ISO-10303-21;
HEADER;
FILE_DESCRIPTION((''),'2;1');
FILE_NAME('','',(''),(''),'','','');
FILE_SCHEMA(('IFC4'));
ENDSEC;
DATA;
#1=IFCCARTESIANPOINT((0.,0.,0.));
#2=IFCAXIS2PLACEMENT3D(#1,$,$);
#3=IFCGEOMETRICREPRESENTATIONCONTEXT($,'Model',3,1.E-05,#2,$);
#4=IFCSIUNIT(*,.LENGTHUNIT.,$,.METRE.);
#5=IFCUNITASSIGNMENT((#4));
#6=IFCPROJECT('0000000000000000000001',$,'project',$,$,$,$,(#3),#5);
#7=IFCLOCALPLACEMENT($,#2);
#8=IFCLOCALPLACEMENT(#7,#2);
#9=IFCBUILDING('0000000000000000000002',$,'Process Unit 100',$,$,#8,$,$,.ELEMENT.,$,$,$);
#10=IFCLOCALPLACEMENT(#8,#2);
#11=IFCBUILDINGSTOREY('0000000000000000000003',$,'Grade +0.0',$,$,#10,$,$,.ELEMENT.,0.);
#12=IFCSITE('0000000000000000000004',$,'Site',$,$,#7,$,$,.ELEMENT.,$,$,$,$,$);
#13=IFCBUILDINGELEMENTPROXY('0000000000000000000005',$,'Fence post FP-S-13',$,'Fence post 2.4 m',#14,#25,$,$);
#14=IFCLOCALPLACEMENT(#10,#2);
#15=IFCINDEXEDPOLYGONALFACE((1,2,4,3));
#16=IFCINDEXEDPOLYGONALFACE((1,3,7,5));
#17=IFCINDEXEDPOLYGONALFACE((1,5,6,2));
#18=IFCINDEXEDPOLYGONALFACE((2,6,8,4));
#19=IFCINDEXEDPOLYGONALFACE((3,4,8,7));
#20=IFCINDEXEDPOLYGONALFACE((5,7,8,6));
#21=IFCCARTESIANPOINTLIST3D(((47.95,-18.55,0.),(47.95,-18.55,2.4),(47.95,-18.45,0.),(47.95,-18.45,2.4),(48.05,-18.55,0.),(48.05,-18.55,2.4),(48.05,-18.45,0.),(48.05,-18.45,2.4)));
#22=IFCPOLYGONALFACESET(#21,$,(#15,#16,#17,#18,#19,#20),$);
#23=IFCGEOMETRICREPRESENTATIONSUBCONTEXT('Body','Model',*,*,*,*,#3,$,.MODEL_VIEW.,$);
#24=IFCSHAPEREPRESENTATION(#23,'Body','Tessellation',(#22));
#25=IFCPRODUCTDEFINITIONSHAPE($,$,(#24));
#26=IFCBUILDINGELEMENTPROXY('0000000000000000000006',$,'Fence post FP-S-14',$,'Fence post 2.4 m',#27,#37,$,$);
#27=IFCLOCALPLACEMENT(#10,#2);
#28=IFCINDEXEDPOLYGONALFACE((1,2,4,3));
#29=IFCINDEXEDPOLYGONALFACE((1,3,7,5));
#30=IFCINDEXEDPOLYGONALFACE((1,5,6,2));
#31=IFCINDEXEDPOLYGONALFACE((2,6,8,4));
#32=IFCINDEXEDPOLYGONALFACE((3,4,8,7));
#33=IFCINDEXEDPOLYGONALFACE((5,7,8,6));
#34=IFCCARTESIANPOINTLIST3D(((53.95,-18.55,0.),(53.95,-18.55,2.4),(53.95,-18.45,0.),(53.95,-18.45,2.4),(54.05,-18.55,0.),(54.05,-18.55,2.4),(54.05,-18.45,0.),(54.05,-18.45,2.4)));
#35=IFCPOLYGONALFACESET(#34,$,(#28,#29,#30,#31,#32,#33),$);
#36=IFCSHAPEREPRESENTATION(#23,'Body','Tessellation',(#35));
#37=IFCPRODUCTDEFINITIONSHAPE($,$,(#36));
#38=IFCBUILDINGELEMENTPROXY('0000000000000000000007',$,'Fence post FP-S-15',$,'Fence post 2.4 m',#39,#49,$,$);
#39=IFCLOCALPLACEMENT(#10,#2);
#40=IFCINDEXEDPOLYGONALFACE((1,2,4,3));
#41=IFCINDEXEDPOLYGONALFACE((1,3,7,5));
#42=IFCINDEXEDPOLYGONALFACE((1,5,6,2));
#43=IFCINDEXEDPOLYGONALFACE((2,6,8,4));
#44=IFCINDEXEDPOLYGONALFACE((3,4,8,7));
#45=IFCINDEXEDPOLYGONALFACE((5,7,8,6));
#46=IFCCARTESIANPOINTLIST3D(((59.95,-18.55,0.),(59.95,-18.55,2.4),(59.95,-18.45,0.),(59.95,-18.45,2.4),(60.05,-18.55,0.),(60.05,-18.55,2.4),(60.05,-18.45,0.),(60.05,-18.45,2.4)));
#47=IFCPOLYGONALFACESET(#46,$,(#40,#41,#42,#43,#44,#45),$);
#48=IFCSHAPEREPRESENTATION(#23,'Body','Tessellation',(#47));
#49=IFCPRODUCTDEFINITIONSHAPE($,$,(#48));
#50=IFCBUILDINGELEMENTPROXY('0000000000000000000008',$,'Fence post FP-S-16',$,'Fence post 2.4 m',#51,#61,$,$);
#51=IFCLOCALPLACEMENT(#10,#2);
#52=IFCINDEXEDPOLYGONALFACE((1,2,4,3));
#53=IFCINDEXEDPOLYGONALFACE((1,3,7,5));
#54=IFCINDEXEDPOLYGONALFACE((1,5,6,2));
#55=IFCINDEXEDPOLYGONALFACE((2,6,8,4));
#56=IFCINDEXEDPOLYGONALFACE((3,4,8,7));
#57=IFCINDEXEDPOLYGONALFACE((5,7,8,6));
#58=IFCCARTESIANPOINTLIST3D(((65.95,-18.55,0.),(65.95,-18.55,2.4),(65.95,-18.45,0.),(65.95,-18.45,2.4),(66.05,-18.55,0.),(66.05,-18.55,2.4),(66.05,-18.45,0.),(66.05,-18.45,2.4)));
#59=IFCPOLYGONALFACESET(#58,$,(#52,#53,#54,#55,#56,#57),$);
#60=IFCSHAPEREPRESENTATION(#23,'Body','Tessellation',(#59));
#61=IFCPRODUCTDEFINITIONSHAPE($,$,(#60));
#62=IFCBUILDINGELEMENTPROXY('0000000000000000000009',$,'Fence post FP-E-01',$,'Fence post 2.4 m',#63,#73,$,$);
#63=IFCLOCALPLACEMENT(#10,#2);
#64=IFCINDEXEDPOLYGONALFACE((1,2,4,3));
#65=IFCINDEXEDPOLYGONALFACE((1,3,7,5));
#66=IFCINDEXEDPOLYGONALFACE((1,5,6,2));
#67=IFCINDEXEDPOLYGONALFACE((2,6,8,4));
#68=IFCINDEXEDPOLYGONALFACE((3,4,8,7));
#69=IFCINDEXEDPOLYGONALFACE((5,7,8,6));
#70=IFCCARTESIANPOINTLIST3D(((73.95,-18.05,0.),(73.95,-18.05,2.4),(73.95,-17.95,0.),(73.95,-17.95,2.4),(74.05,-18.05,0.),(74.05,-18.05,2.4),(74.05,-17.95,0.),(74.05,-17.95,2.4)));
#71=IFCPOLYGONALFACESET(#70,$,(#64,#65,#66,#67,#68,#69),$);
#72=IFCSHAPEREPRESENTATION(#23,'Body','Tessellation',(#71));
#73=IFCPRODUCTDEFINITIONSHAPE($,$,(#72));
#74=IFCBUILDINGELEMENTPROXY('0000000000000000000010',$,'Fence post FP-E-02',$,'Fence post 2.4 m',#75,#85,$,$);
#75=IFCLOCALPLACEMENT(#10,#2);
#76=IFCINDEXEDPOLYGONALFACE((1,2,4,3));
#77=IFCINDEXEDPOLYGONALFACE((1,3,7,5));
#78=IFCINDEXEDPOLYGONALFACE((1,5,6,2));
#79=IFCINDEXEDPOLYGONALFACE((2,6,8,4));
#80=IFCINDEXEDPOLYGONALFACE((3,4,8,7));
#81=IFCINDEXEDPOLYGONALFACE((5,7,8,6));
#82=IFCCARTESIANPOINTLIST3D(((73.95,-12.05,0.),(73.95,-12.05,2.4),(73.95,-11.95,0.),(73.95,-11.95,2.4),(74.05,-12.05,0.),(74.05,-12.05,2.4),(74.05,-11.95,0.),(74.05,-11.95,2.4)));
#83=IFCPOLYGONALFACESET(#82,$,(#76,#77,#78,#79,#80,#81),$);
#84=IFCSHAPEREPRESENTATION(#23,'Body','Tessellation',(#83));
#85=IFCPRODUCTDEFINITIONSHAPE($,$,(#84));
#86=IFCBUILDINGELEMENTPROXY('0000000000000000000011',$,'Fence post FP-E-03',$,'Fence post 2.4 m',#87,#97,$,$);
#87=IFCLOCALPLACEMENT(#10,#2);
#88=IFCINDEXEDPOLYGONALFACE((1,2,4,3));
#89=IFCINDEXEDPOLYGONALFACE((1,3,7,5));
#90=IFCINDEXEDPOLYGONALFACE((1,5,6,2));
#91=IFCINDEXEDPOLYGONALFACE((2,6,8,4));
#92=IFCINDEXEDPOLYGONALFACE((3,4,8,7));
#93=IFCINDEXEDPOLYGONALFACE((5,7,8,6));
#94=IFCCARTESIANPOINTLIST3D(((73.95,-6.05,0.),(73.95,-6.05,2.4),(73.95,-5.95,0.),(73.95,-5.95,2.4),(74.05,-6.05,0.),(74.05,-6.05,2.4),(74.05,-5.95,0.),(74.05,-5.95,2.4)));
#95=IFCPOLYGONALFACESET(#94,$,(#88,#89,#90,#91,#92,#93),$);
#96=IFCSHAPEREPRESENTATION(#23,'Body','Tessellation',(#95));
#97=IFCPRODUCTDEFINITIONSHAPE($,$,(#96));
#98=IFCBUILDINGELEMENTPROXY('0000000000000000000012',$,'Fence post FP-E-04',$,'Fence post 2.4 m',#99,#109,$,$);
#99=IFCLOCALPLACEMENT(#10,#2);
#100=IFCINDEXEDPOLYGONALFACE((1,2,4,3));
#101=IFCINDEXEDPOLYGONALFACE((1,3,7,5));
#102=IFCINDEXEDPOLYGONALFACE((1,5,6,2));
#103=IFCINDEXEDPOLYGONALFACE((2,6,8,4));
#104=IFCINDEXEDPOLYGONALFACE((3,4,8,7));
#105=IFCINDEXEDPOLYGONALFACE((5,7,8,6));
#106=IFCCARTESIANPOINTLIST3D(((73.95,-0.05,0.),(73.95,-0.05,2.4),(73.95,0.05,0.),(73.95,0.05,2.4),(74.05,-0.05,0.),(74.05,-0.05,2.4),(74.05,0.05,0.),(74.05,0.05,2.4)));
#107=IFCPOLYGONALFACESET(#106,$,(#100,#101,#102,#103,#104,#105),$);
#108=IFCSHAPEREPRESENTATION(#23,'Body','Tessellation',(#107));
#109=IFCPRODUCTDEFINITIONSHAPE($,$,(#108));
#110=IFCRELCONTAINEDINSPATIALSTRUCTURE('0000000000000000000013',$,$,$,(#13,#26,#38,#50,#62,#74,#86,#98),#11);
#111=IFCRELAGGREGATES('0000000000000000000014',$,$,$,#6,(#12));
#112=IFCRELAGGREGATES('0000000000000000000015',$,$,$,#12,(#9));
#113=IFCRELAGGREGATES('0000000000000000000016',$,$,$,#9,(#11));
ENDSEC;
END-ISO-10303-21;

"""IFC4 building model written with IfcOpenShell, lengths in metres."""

from ifc_helpers import new_model, si_unit, frame, origin, place, context, subcontext, project, spatial, rectangle, extrude, element, save


model = new_model("IFC4")

# Units and contexts
model_context = context("Model", 3, precision=1e-05, world=origin())
body_context = subcontext(model_context, "Body", "Model", "MODEL_VIEW")
ifc_project = project(units=[si_unit("LENGTHUNIT", "METRE")], contexts=[model_context])

# Site, building, storey
site_placement = place(None, origin())
site = spatial("IfcSite", under=ifc_project, at=site_placement, Name="Site", CompositionType="ELEMENT")
building_placement = place(site_placement, origin())
building = spatial("IfcBuilding", under=site, at=building_placement, Name="Process Unit 100", CompositionType="ELEMENT")
storey_placement = place(building_placement, origin())
storey = spatial("IfcBuildingStorey", under=building, at=storey_placement, Name="Grade +0.0", CompositionType="ELEMENT", Elevation=0.0)

# Building element proxies
for number, where, z_axis, x_axis, name in (
    (1, (48.0, -18.5, 0.0), (0.0, 0.0, 1.0), (1.0, 0.0, 0.0), "Fence post FP-S-13"),
    (2, (54.0, -18.5, 0.0), (0.0, 0.0, 1.0), (1.0, 0.0, 0.0), "Fence post FP-S-14"),
    (3, (60.0, -18.5, 0.0), (0.0, 0.0, 1.0), (1.0, 0.0, 0.0), "Fence post FP-S-15"),
    (4, (66.0, -18.5, 0.0), (0.0, 0.0, 1.0), (1.0, 0.0, 0.0), "Fence post FP-S-16"),
    (5, (74.0, -18.0, 0.0), (0.0, 0.0, 1.0), (1.0, 0.0, 0.0), "Fence post FP-E-01"),
    (6, (74.0, -12.0, 0.0), (0.0, 0.0, 1.0), (1.0, 0.0, 0.0), "Fence post FP-E-02"),
    (7, (74.0, -6.0, 0.0), (0.0, 0.0, 1.0), (1.0, 0.0, 0.0), "Fence post FP-E-03"),
    (8, (74.0, 0.0, 0.0), (0.0, 0.0, 1.0), (1.0, 0.0, 0.0), "Fence post FP-E-04"),
):
    element("IfcBuildingElementProxy", number, at=place(storey_placement, frame(where, z_axis=z_axis, x_axis=x_axis)), inside=storey, Name=name, ObjectType="Fence post 2.4 m", context=body_context, shape_type="SweptSolid", body=[
        extrude(rectangle(XDim=0.1, YDim=0.1), origin(), (0.0, 0.0, 1.0), 2.4),
    ])

save(model, "model.ifc")
